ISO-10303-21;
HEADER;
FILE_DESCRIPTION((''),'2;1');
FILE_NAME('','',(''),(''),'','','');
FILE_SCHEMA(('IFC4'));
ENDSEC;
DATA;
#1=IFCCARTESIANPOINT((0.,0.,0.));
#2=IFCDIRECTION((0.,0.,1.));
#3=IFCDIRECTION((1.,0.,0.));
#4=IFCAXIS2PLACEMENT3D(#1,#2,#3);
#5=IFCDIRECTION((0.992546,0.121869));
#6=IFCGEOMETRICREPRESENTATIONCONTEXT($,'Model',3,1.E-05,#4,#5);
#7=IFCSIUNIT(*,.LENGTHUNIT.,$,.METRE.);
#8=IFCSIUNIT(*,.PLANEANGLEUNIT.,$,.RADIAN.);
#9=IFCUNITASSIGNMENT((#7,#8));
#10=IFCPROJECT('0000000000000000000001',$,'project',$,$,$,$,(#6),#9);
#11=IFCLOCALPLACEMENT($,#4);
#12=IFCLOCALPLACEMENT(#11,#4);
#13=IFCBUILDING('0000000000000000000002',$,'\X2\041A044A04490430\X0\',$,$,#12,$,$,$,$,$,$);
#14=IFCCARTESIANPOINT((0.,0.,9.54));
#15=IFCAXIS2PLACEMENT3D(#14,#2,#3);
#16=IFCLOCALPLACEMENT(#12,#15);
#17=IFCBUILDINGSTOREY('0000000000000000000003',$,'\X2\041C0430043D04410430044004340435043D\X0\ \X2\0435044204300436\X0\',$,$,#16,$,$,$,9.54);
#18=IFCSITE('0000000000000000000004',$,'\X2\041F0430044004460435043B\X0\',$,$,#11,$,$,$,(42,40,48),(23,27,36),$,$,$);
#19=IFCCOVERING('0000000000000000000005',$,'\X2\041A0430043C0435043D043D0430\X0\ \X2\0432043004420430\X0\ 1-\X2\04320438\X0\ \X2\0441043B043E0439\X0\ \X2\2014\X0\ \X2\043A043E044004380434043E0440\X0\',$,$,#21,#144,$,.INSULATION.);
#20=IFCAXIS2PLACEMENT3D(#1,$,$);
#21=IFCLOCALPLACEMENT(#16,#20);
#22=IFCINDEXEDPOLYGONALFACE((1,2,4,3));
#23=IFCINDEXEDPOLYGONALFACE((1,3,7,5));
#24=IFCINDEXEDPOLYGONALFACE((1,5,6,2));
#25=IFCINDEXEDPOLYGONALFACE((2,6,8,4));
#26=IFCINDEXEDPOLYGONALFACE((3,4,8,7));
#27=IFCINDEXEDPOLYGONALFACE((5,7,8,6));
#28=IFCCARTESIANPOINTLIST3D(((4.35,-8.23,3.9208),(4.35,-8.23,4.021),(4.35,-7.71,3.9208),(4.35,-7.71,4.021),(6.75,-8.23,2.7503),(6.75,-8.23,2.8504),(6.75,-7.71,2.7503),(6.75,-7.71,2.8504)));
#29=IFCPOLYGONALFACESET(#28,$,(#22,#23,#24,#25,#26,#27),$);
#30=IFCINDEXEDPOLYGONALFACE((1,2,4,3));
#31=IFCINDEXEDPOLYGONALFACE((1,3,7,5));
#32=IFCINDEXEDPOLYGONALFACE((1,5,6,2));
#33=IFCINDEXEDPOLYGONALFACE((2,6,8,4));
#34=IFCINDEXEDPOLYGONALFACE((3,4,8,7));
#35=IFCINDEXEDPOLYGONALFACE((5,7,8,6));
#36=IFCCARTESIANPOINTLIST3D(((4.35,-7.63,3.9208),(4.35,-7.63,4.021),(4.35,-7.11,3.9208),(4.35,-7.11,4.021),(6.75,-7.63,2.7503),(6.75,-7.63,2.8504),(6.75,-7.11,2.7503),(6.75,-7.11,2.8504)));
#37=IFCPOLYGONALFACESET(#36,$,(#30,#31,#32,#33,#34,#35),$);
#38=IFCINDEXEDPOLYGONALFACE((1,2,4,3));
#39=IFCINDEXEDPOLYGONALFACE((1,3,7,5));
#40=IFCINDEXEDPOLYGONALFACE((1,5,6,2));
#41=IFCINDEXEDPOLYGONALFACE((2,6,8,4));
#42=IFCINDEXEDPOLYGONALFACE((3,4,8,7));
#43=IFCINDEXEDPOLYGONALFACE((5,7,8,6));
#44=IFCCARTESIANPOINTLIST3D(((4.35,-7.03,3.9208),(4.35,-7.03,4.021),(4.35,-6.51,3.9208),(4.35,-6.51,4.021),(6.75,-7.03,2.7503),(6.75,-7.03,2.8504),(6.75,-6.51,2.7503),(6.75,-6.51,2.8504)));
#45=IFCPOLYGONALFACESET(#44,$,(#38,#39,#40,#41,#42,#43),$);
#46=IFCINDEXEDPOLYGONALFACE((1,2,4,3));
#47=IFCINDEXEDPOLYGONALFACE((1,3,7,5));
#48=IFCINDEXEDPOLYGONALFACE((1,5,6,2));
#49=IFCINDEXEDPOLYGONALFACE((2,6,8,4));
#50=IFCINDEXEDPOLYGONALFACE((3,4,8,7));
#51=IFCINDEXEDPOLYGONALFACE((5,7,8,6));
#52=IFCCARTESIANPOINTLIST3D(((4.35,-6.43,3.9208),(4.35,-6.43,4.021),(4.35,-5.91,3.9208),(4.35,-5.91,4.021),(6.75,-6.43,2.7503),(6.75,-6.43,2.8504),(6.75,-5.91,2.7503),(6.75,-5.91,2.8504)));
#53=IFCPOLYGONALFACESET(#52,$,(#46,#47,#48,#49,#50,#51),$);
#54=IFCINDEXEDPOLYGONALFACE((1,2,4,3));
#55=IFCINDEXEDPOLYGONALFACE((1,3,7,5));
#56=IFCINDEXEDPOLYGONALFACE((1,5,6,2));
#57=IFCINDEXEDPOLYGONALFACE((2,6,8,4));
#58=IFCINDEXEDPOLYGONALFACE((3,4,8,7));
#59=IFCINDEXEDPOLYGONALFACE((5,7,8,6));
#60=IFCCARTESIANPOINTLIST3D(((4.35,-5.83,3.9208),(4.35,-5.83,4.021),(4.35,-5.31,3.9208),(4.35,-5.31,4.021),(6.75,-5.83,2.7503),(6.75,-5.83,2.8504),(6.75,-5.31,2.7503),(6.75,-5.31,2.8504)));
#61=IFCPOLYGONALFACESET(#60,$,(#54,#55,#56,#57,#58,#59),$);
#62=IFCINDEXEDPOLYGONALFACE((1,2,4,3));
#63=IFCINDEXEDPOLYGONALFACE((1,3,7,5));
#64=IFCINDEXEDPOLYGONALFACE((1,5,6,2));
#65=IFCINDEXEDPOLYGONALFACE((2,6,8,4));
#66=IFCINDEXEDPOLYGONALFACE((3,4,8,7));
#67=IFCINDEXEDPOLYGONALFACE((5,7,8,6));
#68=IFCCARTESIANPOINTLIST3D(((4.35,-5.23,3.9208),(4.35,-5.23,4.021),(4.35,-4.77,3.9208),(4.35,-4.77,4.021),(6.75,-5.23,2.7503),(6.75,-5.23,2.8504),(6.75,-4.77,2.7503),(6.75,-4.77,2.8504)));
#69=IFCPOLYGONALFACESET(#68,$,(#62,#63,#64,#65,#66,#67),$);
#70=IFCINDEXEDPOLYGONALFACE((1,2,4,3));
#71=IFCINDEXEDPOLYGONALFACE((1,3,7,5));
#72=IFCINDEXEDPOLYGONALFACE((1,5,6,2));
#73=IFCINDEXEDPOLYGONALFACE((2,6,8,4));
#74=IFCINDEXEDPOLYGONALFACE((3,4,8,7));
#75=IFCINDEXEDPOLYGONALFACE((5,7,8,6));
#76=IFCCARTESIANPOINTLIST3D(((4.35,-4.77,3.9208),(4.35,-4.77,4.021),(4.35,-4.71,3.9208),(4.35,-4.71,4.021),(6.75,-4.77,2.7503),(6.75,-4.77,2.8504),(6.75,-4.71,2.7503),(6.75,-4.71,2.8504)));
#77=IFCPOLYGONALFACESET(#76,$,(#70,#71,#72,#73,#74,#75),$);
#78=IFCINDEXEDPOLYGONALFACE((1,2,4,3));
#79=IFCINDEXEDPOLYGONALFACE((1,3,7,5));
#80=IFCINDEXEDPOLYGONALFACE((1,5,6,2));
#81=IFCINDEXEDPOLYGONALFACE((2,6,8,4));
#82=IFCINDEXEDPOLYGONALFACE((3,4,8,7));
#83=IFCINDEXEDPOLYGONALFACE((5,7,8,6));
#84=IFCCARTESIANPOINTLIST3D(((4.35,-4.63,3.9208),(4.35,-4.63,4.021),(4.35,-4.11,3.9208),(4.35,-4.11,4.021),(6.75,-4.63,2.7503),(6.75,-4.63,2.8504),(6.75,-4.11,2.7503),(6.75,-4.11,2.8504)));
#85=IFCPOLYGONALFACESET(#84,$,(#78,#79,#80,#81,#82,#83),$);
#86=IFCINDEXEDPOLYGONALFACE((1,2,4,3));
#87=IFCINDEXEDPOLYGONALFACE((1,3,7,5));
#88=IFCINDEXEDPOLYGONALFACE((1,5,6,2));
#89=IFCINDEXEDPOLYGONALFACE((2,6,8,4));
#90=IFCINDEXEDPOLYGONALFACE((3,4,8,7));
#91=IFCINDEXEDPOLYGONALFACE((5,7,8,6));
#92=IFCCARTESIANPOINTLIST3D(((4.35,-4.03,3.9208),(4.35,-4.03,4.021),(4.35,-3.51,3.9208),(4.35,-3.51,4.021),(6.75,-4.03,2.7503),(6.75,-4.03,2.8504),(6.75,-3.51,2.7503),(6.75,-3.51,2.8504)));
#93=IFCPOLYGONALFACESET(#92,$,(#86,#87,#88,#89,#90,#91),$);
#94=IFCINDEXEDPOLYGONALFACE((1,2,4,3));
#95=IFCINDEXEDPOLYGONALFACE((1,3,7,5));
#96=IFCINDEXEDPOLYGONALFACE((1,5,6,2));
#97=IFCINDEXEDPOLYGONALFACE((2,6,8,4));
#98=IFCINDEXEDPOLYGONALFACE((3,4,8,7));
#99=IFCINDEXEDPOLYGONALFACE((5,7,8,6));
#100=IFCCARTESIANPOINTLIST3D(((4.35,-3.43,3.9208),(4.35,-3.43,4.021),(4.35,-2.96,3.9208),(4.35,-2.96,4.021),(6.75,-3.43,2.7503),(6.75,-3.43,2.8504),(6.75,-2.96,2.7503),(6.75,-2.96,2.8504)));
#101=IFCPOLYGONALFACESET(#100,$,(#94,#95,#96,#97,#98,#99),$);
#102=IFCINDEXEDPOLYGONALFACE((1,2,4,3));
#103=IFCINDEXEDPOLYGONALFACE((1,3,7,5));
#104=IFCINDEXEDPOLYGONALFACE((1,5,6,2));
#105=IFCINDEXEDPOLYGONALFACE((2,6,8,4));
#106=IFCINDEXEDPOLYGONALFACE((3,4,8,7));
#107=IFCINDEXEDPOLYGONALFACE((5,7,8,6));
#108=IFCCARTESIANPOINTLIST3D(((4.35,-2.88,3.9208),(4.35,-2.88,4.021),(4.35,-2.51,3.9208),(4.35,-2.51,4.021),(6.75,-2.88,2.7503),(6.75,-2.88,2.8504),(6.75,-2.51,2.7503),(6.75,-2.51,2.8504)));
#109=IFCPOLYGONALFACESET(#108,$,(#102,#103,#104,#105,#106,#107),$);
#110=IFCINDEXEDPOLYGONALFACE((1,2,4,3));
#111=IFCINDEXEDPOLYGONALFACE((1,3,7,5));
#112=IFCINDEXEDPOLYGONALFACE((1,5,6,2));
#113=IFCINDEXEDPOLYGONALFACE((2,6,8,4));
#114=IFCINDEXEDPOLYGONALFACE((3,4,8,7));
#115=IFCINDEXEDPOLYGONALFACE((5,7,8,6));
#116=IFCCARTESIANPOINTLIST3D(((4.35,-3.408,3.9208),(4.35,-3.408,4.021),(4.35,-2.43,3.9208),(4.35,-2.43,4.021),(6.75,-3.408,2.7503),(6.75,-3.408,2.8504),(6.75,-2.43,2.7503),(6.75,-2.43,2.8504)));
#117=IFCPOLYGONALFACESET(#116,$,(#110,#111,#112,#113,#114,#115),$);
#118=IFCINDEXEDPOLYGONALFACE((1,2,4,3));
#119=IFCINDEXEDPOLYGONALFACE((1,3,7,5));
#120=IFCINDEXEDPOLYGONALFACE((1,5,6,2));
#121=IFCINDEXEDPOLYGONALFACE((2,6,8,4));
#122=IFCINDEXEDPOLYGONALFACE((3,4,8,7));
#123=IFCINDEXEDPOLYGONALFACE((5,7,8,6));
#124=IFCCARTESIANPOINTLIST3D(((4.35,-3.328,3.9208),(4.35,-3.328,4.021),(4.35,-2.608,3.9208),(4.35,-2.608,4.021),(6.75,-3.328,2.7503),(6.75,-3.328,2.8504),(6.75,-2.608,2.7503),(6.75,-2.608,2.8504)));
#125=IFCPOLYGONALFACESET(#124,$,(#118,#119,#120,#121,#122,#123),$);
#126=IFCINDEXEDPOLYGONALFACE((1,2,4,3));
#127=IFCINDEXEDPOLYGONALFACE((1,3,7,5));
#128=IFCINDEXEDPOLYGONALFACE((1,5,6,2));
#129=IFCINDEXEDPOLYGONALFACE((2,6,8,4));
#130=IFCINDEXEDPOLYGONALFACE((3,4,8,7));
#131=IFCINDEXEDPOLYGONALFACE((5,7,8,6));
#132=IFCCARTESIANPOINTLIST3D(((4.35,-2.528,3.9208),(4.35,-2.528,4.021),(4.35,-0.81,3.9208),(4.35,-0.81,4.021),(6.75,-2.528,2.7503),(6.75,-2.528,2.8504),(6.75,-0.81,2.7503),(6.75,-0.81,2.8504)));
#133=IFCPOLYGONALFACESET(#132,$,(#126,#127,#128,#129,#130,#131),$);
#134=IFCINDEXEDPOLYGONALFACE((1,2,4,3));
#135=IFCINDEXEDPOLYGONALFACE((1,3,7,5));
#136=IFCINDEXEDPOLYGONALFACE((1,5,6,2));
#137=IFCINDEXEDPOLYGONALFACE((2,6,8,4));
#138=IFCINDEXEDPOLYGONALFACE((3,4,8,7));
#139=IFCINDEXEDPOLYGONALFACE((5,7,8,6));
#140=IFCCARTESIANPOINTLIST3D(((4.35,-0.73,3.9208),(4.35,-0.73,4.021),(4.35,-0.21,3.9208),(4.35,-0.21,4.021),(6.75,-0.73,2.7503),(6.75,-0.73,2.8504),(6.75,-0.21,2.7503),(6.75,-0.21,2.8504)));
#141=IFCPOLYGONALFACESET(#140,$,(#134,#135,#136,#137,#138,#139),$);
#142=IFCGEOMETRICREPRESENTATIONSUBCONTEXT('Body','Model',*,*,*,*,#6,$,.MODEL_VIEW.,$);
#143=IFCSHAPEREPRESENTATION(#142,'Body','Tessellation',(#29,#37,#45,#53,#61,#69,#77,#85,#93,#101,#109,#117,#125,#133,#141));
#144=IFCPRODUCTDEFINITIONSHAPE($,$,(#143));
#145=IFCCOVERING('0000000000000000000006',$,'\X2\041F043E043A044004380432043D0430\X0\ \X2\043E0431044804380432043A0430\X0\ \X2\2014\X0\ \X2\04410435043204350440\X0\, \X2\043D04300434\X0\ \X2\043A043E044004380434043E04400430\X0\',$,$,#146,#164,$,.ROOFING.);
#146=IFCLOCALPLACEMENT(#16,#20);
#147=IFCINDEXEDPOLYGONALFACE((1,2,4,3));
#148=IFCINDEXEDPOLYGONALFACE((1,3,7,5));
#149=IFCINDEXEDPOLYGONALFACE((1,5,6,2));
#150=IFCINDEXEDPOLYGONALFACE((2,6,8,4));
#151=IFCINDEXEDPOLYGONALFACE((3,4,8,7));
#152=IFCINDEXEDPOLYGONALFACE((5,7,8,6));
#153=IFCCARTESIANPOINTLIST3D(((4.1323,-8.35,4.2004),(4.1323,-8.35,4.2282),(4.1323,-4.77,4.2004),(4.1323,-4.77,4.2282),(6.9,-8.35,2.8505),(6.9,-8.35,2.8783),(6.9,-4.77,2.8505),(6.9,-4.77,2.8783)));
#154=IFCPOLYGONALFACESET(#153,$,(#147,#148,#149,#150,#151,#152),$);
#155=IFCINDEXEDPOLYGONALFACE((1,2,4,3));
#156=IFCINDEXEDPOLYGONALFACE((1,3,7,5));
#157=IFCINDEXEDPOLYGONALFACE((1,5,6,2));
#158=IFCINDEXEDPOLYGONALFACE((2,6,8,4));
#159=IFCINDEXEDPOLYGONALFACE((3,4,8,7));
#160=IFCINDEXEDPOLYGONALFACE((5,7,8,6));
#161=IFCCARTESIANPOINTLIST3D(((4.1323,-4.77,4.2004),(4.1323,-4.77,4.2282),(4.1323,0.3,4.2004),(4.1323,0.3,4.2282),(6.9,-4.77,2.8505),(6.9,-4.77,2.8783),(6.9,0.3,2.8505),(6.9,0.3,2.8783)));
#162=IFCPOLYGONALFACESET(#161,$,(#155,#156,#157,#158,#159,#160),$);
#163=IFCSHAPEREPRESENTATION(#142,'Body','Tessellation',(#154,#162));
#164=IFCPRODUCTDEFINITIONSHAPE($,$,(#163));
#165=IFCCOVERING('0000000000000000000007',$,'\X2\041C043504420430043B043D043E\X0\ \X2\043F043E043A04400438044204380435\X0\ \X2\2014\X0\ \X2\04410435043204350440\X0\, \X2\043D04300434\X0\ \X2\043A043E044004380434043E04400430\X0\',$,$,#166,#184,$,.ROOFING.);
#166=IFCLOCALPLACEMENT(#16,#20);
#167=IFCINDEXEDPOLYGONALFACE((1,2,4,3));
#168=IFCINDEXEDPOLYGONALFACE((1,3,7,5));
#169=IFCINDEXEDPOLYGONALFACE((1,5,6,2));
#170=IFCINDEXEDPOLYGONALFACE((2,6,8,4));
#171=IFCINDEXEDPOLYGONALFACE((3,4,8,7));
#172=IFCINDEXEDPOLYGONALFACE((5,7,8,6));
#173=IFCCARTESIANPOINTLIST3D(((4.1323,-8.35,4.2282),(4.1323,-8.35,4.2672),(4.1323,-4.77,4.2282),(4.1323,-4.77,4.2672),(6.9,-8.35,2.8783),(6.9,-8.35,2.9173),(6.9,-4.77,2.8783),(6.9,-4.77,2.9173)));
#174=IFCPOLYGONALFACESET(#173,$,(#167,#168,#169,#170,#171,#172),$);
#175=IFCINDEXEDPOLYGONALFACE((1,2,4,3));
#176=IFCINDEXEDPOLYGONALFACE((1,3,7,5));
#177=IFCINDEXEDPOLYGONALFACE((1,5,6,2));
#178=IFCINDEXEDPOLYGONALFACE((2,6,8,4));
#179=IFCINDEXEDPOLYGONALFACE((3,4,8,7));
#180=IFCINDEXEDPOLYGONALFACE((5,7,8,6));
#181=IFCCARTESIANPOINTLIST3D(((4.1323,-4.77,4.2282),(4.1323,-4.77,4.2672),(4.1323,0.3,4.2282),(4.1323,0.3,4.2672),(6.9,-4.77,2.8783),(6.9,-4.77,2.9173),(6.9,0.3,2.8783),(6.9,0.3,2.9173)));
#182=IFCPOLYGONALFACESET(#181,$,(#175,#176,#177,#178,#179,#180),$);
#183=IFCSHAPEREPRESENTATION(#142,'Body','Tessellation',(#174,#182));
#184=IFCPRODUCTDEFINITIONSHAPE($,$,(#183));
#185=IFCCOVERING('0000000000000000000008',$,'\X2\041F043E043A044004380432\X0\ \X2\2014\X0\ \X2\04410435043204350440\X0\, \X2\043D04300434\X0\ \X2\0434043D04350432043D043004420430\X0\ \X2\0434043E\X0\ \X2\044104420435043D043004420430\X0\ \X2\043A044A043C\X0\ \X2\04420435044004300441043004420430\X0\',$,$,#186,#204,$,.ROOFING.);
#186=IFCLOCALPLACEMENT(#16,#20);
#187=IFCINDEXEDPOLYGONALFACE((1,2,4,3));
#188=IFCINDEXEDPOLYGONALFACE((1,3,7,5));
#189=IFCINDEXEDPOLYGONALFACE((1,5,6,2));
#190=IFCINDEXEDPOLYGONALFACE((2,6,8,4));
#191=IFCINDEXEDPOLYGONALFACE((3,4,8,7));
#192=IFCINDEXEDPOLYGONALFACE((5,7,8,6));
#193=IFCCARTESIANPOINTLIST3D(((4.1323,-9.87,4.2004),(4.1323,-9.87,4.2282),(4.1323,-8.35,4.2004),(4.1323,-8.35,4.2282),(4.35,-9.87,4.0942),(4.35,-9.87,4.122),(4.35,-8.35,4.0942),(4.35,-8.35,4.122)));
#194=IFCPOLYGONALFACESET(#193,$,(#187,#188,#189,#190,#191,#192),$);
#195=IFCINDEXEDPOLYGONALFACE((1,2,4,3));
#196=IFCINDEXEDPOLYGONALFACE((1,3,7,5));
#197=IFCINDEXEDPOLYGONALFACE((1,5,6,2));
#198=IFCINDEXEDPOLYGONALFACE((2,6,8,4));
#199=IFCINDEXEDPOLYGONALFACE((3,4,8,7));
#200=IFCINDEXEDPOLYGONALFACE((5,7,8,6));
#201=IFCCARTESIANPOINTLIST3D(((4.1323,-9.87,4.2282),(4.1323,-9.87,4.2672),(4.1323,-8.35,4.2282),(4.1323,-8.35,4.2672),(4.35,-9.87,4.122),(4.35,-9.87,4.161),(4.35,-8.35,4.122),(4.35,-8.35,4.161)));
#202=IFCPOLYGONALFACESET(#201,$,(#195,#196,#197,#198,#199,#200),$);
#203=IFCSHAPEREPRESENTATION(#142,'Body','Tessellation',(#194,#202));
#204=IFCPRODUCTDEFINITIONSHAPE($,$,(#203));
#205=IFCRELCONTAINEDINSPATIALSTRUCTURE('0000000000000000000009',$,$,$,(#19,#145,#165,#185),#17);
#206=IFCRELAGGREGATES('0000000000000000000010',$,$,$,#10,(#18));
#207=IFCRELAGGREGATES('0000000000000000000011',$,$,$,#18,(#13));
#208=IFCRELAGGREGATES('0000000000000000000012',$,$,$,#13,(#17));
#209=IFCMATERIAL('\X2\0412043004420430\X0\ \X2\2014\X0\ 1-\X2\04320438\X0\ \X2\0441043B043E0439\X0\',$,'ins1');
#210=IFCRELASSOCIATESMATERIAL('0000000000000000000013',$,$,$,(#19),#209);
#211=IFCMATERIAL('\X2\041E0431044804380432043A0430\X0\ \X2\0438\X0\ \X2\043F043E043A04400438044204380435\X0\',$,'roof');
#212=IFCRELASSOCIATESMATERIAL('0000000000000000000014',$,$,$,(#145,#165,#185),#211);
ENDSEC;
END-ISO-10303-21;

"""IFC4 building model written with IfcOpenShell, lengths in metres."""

from ifc_helpers import new_model, si_unit, direction, frame, origin_with_axes, place, context, subcontext, project, spatial, polyline, outline, extrude, material, element, save


model = new_model("IFC4")

# Units and contexts
model_context = context("Model", 3, precision=1e-05, world=origin_with_axes(), true_north=direction((0.992546, 0.121869)))
body_context = subcontext(model_context, "Body", "Model", "MODEL_VIEW")
ifc_project = project(units=[si_unit("LENGTHUNIT", "METRE"), si_unit("PLANEANGLEUNIT", "RADIAN")], contexts=[model_context])

# Site, building, storey
site_placement = place(None, origin_with_axes())
site = spatial("IfcSite", under=ifc_project, at=site_placement, Name="Парцел", RefLatitude=(42, 40, 48), RefLongitude=(23, 27, 36))
building_placement = place(site_placement, origin_with_axes())
building = spatial("IfcBuilding", under=site, at=building_placement, Name="Къща")
storey_placement = place(building_placement, frame((0.0, 0.0, 9.54), z_axis=(0.0, 0.0, 1.0), x_axis=(1.0, 0.0, 0.0)))
storey = spatial("IfcBuildingStorey", under=building, at=storey_placement, Name="Мансарден етаж", Elevation=9.54)

# Coverings
ifc_material_1 = material(Name="Вата — 1-ви слой", Category="ins1")
covering_1_placement = place(storey_placement, origin_with_axes())
element("IfcCovering", 1, at=covering_1_placement, inside=storey, material=ifc_material_1, Name="Каменна вата 1-ви слой — коридор", PredefinedType="INSULATION", context=body_context, shape_type="SweptSolid", body=[
    extrude(outline(polyline([(6.75, -2.7503), (4.35, -3.9208), (4.35, -4.021), (6.75, -2.8504), (6.75, -2.7503)])), frame((0.0, -8.23, 0.0), z_axis=(0.0, 1.0, 0.0), x_axis=(1.0, 0.0, 0.0)), (0.0, 0.0, 1.0), 0.52),
    extrude(outline(polyline([(6.75, -2.7503), (4.35, -3.9208), (4.35, -4.021), (6.75, -2.8504), (6.75, -2.7503)])), frame((0.0, -7.63, 0.0), z_axis=(0.0, 1.0, 0.0), x_axis=(1.0, 0.0, 0.0)), (0.0, 0.0, 1.0), 0.52),
    extrude(outline(polyline([(6.75, -2.7503), (4.35, -3.9208), (4.35, -4.021), (6.75, -2.8504), (6.75, -2.7503)])), frame((0.0, -7.03, 0.0), z_axis=(0.0, 1.0, 0.0), x_axis=(1.0, 0.0, 0.0)), (0.0, 0.0, 1.0), 0.52),
    extrude(outline(polyline([(6.75, -2.7503), (4.35, -3.9208), (4.35, -4.021), (6.75, -2.8504), (6.75, -2.7503)])), frame((0.0, -6.43, 0.0), z_axis=(0.0, 1.0, 0.0), x_axis=(1.0, 0.0, 0.0)), (0.0, 0.0, 1.0), 0.52),
    extrude(outline(polyline([(6.75, -2.7503), (4.35, -3.9208), (4.35, -4.021), (6.75, -2.8504), (6.75, -2.7503)])), frame((0.0, -5.83, 0.0), z_axis=(0.0, 1.0, 0.0), x_axis=(1.0, 0.0, 0.0)), (0.0, 0.0, 1.0), 0.52),
    extrude(outline(polyline([(6.75, -2.7503), (4.35, -3.9208), (4.35, -4.021), (6.75, -2.8504), (6.75, -2.7503)])), frame((0.0, -5.23, 0.0), z_axis=(0.0, 1.0, 0.0), x_axis=(1.0, 0.0, 0.0)), (0.0, 0.0, 1.0), 0.46),
    extrude(outline(polyline([(6.75, -2.7503), (4.35, -3.9208), (4.35, -4.021), (6.75, -2.8504), (6.75, -2.7503)])), frame((0.0, -4.77, 0.0), z_axis=(0.0, 1.0, 0.0), x_axis=(1.0, 0.0, 0.0)), (0.0, 0.0, 1.0), 0.06),
    extrude(outline(polyline([(6.75, -2.7503), (4.35, -3.9208), (4.35, -4.021), (6.75, -2.8504), (6.75, -2.7503)])), frame((0.0, -4.63, 0.0), z_axis=(0.0, 1.0, 0.0), x_axis=(1.0, 0.0, 0.0)), (0.0, 0.0, 1.0), 0.52),
    extrude(outline(polyline([(6.75, -2.7503), (4.35, -3.9208), (4.35, -4.021), (6.75, -2.8504), (6.75, -2.7503)])), frame((0.0, -4.03, 0.0), z_axis=(0.0, 1.0, 0.0), x_axis=(1.0, 0.0, 0.0)), (0.0, 0.0, 1.0), 0.52),
    extrude(outline(polyline([(6.75, -2.7503), (4.35, -3.9208), (4.35, -4.021), (6.75, -2.8504), (6.75, -2.7503)])), frame((0.0, -3.43, 0.0), z_axis=(0.0, 1.0, 0.0), x_axis=(1.0, 0.0, 0.0)), (0.0, 0.0, 1.0), 0.47),
    extrude(outline(polyline([(6.75, -2.7503), (4.35, -3.9208), (4.35, -4.021), (6.75, -2.8504), (6.75, -2.7503)])), frame((0.0, -2.88, 0.0), z_axis=(0.0, 1.0, 0.0), x_axis=(1.0, 0.0, 0.0)), (0.0, 0.0, 1.0), 0.37),
    extrude(outline(polyline([(6.75, -2.7503), (4.35, -3.9208), (4.35, -4.021), (6.75, -2.8504), (6.75, -2.7503)])), frame((0.0, -3.408, 0.0), z_axis=(0.0, 1.0, 0.0), x_axis=(1.0, 0.0, 0.0)), (0.0, 0.0, 1.0), 0.978),
    extrude(outline(polyline([(6.75, -2.7503), (4.35, -3.9208), (4.35, -4.021), (6.75, -2.8504), (6.75, -2.7503)])), frame((0.0, -3.328, 0.0), z_axis=(0.0, 1.0, 0.0), x_axis=(1.0, 0.0, 0.0)), (0.0, 0.0, 1.0), 0.72),
    extrude(outline(polyline([(6.75, -2.7503), (4.35, -3.9208), (4.35, -4.021), (6.75, -2.8504), (6.75, -2.7503)])), frame((0.0, -2.528, 0.0), z_axis=(0.0, 1.0, 0.0), x_axis=(1.0, 0.0, 0.0)), (0.0, 0.0, 1.0), 1.718),
    extrude(outline(polyline([(6.75, -2.7503), (4.35, -3.9208), (4.35, -4.021), (6.75, -2.8504), (6.75, -2.7503)])), frame((0.0, -0.73, 0.0), z_axis=(0.0, 1.0, 0.0), x_axis=(1.0, 0.0, 0.0)), (0.0, 0.0, 1.0), 0.52),
])
ifc_material_2 = material(Name="Обшивка и покритие", Category="roof")
covering_2_placement = place(storey_placement, origin_with_axes())
element("IfcCovering", 2, at=covering_2_placement, inside=storey, material=ifc_material_2, Name="Покривна обшивка — север, над коридора", PredefinedType="ROOFING", context=body_context, shape_type="SweptSolid", body=[
    extrude(outline(polyline([(6.9, -2.8505), (4.1323, -4.2004), (4.1323, -4.2282), (6.9, -2.8783), (6.9, -2.8505)])), frame((0.0, -8.35, 0.0), z_axis=(0.0, 1.0, 0.0), x_axis=(1.0, 0.0, 0.0)), (0.0, 0.0, 1.0), 3.58),
    extrude(outline(polyline([(6.9, -2.8505), (4.1323, -4.2004), (4.1323, -4.2282), (6.9, -2.8783), (6.9, -2.8505)])), frame((0.0, -4.77, 0.0), z_axis=(0.0, 1.0, 0.0), x_axis=(1.0, 0.0, 0.0)), (0.0, 0.0, 1.0), 5.07),
])
covering_3_placement = place(storey_placement, origin_with_axes())
element("IfcCovering", 3, at=covering_3_placement, inside=storey, material=ifc_material_2, Name="Метално покритие — север, над коридора", PredefinedType="ROOFING", context=body_context, shape_type="SweptSolid", body=[
    extrude(outline(polyline([(6.9, -2.8783), (4.1323, -4.2282), (4.1323, -4.2672), (6.9, -2.9173), (6.9, -2.8783)])), frame((0.0, -8.35, 0.0), z_axis=(0.0, 1.0, 0.0), x_axis=(1.0, 0.0, 0.0)), (0.0, 0.0, 1.0), 3.58),
    extrude(outline(polyline([(6.9, -2.8783), (4.1323, -4.2282), (4.1323, -4.2672), (6.9, -2.9173), (6.9, -2.8783)])), frame((0.0, -4.77, 0.0), z_axis=(0.0, 1.0, 0.0), x_axis=(1.0, 0.0, 0.0)), (0.0, 0.0, 1.0), 5.07),
])
covering_4_placement = place(storey_placement, origin_with_axes())
element("IfcCovering", 4, at=covering_4_placement, inside=storey, material=ifc_material_2, Name="Покрив — север, над дневната до стената към терасата", PredefinedType="ROOFING", context=body_context, shape_type="SweptSolid", body=[
    extrude(outline(polyline([(4.35, -4.0942), (4.1323, -4.2004), (4.1323, -4.2282), (4.35, -4.122), (4.35, -4.0942)])), frame((0.0, -9.87, 0.0), z_axis=(0.0, 1.0, 0.0), x_axis=(1.0, 0.0, 0.0)), (0.0, 0.0, 1.0), 1.52),
    extrude(outline(polyline([(4.35, -4.122), (4.1323, -4.2282), (4.1323, -4.2672), (4.35, -4.161), (4.35, -4.122)])), frame((0.0, -9.87, 0.0), z_axis=(0.0, 1.0, 0.0), x_axis=(1.0, 0.0, 0.0)), (0.0, 0.0, 1.0), 1.52),
])

save(model, "model.ifc")
